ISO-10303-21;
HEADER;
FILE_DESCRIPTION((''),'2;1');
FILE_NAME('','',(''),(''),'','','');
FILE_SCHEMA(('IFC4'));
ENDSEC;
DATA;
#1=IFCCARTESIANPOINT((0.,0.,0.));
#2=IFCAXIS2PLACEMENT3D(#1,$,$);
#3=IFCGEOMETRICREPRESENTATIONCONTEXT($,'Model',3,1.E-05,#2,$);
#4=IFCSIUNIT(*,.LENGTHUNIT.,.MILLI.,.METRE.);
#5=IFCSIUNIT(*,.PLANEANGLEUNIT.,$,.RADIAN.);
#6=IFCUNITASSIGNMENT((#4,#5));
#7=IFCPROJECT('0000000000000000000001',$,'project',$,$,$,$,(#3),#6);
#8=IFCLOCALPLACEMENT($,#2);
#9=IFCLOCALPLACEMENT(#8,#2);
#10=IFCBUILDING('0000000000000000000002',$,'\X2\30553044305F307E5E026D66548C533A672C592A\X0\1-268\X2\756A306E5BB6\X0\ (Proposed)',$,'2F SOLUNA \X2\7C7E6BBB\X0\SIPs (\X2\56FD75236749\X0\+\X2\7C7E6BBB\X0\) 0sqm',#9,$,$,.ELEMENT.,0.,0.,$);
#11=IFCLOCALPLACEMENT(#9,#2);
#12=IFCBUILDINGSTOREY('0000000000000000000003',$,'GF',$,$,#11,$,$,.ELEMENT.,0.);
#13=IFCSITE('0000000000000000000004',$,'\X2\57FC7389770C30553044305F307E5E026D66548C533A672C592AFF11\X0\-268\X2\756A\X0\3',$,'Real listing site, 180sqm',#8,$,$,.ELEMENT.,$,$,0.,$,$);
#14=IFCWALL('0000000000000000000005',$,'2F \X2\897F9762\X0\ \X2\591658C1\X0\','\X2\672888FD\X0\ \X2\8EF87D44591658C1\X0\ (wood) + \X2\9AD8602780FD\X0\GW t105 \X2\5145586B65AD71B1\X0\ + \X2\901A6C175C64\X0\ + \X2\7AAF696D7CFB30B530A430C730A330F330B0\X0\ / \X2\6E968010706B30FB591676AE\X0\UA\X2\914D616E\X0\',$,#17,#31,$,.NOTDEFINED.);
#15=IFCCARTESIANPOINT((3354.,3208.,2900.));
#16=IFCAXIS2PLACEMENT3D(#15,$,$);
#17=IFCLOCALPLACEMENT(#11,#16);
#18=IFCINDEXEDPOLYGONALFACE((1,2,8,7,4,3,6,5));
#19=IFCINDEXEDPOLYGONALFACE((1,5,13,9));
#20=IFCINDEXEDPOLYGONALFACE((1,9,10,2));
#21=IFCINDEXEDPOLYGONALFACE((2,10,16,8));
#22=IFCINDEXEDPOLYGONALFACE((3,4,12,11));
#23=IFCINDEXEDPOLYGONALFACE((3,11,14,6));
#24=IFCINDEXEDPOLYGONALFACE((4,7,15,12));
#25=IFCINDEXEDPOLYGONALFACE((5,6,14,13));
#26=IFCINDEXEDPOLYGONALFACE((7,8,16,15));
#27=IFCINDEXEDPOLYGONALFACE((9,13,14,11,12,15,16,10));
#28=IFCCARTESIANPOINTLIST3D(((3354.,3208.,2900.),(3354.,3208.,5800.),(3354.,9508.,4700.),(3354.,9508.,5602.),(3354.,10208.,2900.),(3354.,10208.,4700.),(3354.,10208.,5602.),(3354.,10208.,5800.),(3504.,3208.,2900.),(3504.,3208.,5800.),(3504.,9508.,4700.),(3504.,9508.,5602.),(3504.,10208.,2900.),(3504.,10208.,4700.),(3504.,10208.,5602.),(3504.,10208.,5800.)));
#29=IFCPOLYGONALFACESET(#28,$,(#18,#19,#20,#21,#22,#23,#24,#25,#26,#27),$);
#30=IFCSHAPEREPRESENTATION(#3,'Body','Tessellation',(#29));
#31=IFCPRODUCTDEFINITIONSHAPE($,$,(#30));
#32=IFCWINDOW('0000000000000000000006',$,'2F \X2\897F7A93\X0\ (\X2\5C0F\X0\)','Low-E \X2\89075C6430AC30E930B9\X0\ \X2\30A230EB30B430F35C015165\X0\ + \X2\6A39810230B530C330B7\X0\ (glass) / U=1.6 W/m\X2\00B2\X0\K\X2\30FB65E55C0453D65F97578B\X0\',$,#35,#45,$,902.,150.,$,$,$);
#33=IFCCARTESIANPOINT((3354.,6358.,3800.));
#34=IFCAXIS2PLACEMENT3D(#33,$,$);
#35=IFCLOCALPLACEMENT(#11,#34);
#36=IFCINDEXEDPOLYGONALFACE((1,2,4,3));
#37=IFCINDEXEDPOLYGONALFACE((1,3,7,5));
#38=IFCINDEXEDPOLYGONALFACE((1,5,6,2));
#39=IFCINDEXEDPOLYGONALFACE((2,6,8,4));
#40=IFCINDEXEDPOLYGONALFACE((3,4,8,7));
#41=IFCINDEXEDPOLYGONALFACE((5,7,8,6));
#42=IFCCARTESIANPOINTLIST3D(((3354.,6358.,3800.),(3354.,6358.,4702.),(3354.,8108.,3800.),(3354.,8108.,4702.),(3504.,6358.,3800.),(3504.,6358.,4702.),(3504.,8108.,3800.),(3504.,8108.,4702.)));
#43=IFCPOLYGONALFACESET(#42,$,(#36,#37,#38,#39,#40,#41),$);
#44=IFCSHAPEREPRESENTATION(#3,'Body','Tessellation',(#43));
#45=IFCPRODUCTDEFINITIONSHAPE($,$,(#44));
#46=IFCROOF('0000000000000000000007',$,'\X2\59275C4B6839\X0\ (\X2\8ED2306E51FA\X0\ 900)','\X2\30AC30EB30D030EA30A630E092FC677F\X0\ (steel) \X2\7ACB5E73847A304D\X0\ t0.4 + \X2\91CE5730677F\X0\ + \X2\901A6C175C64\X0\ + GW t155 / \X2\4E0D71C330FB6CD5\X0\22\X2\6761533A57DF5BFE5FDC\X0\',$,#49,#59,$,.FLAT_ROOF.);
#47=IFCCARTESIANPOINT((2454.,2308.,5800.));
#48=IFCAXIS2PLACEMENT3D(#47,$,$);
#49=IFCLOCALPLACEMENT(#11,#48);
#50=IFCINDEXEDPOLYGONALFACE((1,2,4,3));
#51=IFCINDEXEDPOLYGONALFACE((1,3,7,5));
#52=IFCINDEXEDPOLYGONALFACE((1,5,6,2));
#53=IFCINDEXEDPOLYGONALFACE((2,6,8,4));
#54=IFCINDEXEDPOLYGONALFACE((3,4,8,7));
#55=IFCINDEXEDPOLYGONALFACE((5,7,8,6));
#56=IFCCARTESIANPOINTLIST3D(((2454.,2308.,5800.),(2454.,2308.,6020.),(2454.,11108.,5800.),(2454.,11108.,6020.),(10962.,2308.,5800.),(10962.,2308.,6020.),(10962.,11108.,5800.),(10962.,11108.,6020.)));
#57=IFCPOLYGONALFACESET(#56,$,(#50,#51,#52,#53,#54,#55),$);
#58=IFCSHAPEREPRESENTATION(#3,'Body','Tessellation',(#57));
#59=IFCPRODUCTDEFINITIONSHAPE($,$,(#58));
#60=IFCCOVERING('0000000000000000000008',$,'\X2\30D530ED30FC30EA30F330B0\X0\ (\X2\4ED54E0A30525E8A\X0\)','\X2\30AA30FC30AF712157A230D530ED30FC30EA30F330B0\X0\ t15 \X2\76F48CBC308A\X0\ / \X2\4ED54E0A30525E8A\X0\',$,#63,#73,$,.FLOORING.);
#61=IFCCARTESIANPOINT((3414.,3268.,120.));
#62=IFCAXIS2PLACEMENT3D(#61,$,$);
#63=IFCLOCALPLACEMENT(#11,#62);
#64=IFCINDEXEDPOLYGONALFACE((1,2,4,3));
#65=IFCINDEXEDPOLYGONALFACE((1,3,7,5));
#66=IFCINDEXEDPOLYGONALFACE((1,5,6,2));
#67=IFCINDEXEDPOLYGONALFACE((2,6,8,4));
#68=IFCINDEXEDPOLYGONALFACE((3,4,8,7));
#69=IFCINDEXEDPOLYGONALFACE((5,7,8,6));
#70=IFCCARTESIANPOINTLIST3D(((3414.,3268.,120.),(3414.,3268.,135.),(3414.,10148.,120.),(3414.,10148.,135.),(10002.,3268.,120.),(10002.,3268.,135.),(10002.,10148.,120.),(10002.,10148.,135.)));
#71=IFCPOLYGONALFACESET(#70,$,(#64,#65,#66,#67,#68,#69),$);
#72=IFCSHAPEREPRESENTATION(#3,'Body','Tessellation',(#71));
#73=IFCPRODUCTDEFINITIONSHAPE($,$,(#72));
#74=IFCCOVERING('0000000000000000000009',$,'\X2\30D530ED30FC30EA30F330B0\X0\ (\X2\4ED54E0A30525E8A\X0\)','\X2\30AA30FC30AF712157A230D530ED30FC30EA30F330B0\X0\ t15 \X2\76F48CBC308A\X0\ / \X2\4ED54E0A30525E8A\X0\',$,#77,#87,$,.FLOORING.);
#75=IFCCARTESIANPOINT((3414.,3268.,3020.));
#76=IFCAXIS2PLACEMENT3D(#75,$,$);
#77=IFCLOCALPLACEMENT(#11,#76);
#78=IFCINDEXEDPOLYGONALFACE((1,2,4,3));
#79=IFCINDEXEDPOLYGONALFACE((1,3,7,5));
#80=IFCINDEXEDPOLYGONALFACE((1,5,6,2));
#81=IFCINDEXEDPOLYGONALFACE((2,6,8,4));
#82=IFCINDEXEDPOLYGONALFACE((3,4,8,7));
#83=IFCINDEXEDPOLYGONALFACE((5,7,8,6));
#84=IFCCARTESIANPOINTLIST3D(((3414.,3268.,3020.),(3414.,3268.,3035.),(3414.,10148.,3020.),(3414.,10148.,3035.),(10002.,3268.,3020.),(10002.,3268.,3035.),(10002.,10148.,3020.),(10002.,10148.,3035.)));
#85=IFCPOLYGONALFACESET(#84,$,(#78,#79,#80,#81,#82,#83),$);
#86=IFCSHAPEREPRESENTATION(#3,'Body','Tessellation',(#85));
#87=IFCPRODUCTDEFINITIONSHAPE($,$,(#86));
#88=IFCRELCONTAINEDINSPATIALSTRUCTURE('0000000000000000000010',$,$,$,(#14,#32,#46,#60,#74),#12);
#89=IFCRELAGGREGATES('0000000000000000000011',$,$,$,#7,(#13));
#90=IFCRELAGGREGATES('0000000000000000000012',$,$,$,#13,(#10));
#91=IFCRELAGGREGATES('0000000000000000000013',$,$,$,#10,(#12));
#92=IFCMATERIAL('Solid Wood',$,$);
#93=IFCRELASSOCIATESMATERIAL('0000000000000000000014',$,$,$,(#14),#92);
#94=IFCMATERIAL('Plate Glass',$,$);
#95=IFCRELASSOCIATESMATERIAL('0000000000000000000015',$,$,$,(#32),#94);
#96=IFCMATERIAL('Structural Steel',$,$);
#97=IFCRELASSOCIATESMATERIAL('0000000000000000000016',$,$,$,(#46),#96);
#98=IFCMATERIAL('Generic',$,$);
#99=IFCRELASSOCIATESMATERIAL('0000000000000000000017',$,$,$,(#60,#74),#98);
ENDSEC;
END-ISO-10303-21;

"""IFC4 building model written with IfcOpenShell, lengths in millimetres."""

from ifc_helpers import new_model, si_unit, frame, frame_2d, origin, place, context, project, spatial, rectangle, extrude, material, element, fill, save


model = new_model("IFC4")

# Units and contexts
model_context = context("Model", 3, precision=1e-05, world=origin())
ifc_project = project(units=[si_unit("LENGTHUNIT", "METRE", prefix="MILLI"), si_unit("PLANEANGLEUNIT", "RADIAN")], contexts=[model_context])

# Site, building, storey
site_placement = place(None, origin())
site = spatial("IfcSite", under=ifc_project, at=site_placement, Name="埼玉県さいたま市浦和区本太１-268番3", ObjectType="Real listing site, 180sqm", CompositionType="ELEMENT", RefElevation=0.0)
building_placement = place(site_placement, origin())
building = spatial("IfcBuilding", under=site, at=building_placement, Name="さいたま市浦和区本太1-268番の家 (Proposed)", ObjectType="2F SOLUNA 籾殻SIPs (国産杉+籾殻) 0sqm", CompositionType="ELEMENT", ElevationOfRefHeight=0.0, ElevationOfTerrain=0.0)
storey_placement = place(building_placement, origin())
storey = spatial("IfcBuildingStorey", under=building, at=storey_placement, Name="GF", CompositionType="ELEMENT", Elevation=0.0)

# Shared definitions
ifc_material_1 = material(Name="Solid Wood")

# Shared definitions
ifc_material_2 = material(Name="Plate Glass")

# Wall, opening, window
wall_1_placement = place(storey_placement, frame((3354.0, 3208.0, 2900.0)))
wall_1 = element("IfcWall", 1, at=wall_1_placement, inside=storey, material=ifc_material_1, Name="2F 西面 外壁", Description="木製 軸組外壁 (wood) + 高性能GW t105 充填断熱 + 通気層 + 窯業系サイディング / 準耐火・外皮UA配慮", PredefinedType="NOTDEFINED", context=model_context, shape_type="SweptSolid", body=[
    extrude(rectangle(XDim=150.0, YDim=7000.0, at=frame_2d((75.0, 3500.0))), frame((3354.0, 3208.0, 2900.0)), (0.0, 0.0, 1.0), 2900.0),
])
opening_1_placement = place(storey_placement, frame((3354.0, 6358.0, 3800.0)))
opening_1 = element("IfcOpeningElement", 2, at=opening_1_placement, cuts=wall_1, PredefinedType="NOTDEFINED", context=model_context, shape_type="SweptSolid", body=[
    extrude(rectangle(XDim=150.0, YDim=1750.0, at=frame_2d((75.0, 875.0))), frame((3354.0, 6358.0, 3800.0)), (0.0, 0.0, 1.0), 902.0),
])
window_1_placement = place(storey_placement, frame((3354.0, 6358.0, 3800.0)))
window_1 = element("IfcWindow", 3, at=window_1_placement, inside=storey, material=ifc_material_2, Name="2F 西窓 (小)", Description="Low-E 複層ガラス アルゴン封入 + 樹脂サッシ (glass) / U=1.6 W/m²K・日射取得型", OverallHeight=902.0, OverallWidth=150.0, context=model_context, shape_type="SweptSolid", body=[
    extrude(rectangle(XDim=150.0, YDim=1750.0, at=frame_2d((75.0, 875.0))), frame((3354.0, 6358.0, 3800.0)), (0.0, 0.0, 1.0), 902.0),
])
fill(opening_1, window_1)

# Roof
ifc_material_3 = material(Name="Structural Steel")
roof_placement = place(storey_placement, frame((2454.0, 2308.0, 5800.0)))
element("IfcRoof", 4, at=roof_placement, inside=storey, material=ifc_material_3, Name="大屋根 (軒の出 900)", Description="ガルバリウム鋼板 (steel) 立平葺き t0.4 + 野地板 + 通気層 + GW t155 / 不燃・法22条区域対応", PredefinedType="FLAT_ROOF", context=model_context, shape_type="SweptSolid", body=[
    extrude(rectangle(XDim=8508.0, YDim=8800.0, at=frame_2d((4254.0, 4400.0))), frame((2454.0, 2308.0, 5800.0)), (0.0, 0.0, 1.0), 220.0),
])

# Coverings
ifc_material_4 = material(Name="Generic")
covering_1_placement = place(storey_placement, frame((3414.0, 3268.0, 120.0)))
element("IfcCovering", 5, at=covering_1_placement, inside=storey, material=ifc_material_4, Name="フローリング (仕上げ床)", Description="オーク無垢フローリング t15 直貼り / 仕上げ床", PredefinedType="FLOORING", context=model_context, shape_type="SweptSolid", body=[
    extrude(rectangle(XDim=6588.0, YDim=6880.0, at=frame_2d((3294.0, 3440.0))), frame((3414.0, 3268.0, 120.0)), (0.0, 0.0, 1.0), 15.0),
])
covering_2_placement = place(storey_placement, frame((3414.0, 3268.0, 3020.0)))
element("IfcCovering", 6, at=covering_2_placement, inside=storey, material=ifc_material_4, Name="フローリング (仕上げ床)", Description="オーク無垢フローリング t15 直貼り / 仕上げ床", PredefinedType="FLOORING", context=model_context, shape_type="SweptSolid", body=[
    extrude(rectangle(XDim=6588.0, YDim=6880.0, at=frame_2d((3294.0, 3440.0))), frame((3414.0, 3268.0, 3020.0)), (0.0, 0.0, 1.0), 15.0),
])

save(model, "model.ifc")
